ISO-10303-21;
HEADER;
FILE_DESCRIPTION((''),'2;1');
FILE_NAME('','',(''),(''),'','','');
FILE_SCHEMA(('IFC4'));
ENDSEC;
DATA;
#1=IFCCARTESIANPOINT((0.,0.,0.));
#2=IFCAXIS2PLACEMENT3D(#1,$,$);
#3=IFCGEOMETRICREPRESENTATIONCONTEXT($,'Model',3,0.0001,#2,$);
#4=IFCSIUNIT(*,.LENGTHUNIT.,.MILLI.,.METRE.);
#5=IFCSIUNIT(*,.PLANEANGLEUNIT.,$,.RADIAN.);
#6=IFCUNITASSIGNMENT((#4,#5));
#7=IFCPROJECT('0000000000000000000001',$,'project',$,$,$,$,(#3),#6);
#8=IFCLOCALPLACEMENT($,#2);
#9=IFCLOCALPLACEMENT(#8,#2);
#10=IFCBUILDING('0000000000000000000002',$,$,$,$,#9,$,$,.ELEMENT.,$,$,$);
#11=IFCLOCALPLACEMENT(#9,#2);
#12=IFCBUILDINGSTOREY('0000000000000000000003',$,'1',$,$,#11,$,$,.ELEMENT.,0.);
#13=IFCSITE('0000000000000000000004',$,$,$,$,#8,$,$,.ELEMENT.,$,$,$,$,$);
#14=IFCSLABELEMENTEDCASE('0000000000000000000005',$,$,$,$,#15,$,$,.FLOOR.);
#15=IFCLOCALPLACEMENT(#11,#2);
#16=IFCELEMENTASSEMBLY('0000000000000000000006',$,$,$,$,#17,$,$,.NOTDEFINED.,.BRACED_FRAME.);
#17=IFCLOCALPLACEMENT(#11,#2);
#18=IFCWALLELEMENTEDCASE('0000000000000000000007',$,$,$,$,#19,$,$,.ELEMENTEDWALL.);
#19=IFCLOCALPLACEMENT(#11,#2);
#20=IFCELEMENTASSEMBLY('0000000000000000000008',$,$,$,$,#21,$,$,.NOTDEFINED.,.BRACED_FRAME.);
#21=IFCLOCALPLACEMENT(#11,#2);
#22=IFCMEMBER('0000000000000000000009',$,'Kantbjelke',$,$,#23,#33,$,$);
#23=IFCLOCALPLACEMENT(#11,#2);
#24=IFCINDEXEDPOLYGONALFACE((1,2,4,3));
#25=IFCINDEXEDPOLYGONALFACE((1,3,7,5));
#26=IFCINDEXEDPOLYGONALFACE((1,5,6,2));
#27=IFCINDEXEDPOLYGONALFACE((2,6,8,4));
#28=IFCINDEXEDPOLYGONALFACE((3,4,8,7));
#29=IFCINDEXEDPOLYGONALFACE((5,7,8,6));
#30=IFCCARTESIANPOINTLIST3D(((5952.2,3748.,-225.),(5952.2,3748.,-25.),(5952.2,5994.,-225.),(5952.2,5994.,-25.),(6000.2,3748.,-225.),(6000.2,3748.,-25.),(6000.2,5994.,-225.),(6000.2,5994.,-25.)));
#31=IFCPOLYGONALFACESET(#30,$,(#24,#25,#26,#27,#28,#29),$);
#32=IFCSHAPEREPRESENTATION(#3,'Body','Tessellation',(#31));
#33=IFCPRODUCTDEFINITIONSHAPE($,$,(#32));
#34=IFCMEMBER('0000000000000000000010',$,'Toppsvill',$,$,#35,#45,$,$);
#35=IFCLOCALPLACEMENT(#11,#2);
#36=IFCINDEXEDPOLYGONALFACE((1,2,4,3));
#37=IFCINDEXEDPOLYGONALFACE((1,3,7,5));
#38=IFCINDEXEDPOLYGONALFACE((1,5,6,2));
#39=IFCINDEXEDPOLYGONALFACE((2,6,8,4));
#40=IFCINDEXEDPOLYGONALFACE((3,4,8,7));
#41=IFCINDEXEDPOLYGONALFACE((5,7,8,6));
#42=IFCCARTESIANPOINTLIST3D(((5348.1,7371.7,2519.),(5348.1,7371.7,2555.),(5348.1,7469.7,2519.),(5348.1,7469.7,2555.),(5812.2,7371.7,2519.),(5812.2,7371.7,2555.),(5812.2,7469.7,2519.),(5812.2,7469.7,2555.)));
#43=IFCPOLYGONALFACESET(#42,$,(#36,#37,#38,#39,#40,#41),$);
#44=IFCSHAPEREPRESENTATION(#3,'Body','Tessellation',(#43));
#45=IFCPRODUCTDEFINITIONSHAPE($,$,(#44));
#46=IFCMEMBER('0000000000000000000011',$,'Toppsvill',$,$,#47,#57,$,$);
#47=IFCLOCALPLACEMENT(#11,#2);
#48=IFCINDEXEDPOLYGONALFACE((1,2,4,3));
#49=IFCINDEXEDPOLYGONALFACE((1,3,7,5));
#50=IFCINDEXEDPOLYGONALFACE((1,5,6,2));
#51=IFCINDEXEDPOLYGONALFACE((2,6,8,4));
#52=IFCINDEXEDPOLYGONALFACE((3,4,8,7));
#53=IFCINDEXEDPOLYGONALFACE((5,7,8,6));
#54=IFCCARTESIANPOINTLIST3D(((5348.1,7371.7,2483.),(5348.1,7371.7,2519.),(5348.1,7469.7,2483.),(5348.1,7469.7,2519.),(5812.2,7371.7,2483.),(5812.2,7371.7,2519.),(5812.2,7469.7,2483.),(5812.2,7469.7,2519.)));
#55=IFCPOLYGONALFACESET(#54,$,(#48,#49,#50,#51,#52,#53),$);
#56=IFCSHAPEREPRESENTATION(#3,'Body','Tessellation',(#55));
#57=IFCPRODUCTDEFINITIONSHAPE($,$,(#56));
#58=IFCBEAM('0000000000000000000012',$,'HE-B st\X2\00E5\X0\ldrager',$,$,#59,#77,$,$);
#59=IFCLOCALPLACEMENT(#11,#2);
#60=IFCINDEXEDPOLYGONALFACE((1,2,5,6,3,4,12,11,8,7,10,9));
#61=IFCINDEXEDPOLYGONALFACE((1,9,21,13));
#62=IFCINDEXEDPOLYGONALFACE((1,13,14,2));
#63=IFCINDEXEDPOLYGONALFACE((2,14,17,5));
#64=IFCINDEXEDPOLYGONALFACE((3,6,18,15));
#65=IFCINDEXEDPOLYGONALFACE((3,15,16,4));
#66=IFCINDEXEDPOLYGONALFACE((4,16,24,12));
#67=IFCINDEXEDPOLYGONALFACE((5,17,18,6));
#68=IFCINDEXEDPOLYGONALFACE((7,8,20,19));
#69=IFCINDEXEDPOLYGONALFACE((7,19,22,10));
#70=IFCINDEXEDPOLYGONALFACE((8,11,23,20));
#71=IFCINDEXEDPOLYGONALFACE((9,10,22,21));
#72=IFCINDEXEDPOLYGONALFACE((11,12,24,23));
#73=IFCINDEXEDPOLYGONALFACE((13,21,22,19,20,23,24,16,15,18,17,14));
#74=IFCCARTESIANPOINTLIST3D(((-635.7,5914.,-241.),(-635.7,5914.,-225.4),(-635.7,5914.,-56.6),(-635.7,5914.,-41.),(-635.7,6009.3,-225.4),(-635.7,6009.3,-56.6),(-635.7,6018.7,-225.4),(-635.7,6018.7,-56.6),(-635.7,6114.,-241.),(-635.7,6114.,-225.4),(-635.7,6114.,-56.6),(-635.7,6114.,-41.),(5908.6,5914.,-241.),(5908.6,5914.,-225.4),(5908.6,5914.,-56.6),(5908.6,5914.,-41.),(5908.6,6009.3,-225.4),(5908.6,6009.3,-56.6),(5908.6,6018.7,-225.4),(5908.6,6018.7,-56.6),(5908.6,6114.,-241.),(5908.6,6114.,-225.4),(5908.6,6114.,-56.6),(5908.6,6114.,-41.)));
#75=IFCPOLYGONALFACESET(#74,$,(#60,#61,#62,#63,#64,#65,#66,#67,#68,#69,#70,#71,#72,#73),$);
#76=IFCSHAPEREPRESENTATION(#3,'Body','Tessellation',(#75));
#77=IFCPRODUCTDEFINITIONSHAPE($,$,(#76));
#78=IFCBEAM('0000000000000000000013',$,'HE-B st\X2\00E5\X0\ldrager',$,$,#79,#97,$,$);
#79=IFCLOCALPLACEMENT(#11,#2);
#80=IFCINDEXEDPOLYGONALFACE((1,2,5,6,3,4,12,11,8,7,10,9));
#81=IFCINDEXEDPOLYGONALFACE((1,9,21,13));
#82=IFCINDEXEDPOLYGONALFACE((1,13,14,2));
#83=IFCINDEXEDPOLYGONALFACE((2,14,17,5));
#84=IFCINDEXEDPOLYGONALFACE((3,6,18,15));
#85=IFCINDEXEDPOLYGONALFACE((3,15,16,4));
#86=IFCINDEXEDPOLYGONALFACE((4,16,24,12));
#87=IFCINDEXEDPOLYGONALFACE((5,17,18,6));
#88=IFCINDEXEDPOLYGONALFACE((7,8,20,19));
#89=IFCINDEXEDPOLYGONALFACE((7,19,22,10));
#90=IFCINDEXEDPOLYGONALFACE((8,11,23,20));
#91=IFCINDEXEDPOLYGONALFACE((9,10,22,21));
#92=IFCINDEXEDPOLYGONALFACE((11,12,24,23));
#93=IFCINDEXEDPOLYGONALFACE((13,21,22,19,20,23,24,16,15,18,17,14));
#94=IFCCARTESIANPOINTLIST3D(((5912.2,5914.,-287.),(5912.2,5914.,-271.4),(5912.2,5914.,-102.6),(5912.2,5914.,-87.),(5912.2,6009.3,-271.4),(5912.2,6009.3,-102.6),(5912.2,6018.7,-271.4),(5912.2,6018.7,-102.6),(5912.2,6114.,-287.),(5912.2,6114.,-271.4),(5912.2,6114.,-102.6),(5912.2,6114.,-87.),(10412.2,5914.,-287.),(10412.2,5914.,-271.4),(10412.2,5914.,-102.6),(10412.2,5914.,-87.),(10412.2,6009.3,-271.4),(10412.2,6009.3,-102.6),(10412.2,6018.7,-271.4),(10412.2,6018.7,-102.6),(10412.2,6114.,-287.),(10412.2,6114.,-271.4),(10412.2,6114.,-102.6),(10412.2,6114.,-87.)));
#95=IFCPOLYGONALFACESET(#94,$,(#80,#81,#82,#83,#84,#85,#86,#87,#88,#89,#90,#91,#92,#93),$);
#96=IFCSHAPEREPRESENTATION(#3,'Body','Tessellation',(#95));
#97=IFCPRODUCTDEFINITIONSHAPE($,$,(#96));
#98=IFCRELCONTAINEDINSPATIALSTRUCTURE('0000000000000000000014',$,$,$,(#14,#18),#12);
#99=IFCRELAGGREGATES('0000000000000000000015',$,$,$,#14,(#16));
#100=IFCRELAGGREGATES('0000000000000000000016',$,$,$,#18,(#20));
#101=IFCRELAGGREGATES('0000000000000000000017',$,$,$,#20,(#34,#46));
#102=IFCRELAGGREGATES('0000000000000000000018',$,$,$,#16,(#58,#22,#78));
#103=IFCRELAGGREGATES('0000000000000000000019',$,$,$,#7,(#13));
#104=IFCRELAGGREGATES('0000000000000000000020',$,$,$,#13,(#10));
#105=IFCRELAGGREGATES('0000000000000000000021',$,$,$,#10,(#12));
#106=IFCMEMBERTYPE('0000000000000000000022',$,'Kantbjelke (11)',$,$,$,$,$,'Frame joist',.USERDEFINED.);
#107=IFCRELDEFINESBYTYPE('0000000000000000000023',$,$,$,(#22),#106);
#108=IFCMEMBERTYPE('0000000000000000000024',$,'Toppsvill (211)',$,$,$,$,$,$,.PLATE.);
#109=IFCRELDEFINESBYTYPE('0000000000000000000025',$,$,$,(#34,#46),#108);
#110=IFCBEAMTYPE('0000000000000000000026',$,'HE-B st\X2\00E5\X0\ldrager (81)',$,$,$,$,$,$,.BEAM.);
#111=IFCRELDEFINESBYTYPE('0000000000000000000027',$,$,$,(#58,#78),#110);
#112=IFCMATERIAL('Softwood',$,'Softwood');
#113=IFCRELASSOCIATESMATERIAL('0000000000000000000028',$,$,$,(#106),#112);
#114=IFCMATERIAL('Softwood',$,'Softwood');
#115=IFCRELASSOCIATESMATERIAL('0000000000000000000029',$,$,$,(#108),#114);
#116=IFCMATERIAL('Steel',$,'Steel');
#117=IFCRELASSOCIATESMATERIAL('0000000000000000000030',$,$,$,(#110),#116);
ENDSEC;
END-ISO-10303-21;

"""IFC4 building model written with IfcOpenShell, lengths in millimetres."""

from ifc_helpers import new_model, si_unit, frame, origin, place, context, project, spatial, polyline, rectangle, outline, extrude, clip, halfspace, material, material_profile, profile_set, type_object, element, aggregate, save


model = new_model("IFC4")

# Units and contexts
model_context = context("Model", 3, precision=0.0001, world=origin())
ifc_project = project(units=[si_unit("LENGTHUNIT", "METRE", prefix="MILLI"), si_unit("PLANEANGLEUNIT", "RADIAN")], contexts=[model_context])

# Site, building, storey
site_placement = place(None, origin())
site = spatial("IfcSite", under=ifc_project, at=site_placement, CompositionType="ELEMENT")
building_placement = place(site_placement, origin())
building = spatial("IfcBuilding", under=site, at=building_placement, CompositionType="ELEMENT")
storey_placement = place(building_placement, origin())
storey = spatial("IfcBuildingStorey", under=building, at=storey_placement, Name="1", CompositionType="ELEMENT", Elevation=0.0)

# Slab, element assembly
slab_placement = place(storey_placement, origin())
slab = element("IfcSlabElementedCase", 1, at=slab_placement, inside=storey, PredefinedType="FLOOR")
assembly_1_placement = place(slab_placement, frame((0.0, 0.0, -225.0)))
assembly_1 = element("IfcElementAssembly", 2, at=assembly_1_placement, AssemblyPlace="NOTDEFINED", PredefinedType="BRACED_FRAME")
aggregate(slab, [assembly_1])

# Wall, element assembly
wall_1_placement = place(storey_placement, frame((5812.2, 7371.7, 0.0), z_axis=(0.0, 1.0, 0.0), x_axis=(-1.0, 0.0, 0.0)))
wall_1 = element("IfcWallElementedCase", 3, at=wall_1_placement, inside=storey, PredefinedType="ELEMENTEDWALL")
assembly_2_placement = place(wall_1_placement, origin())
assembly_2 = element("IfcElementAssembly", 4, at=assembly_2_placement, AssemblyPlace="NOTDEFINED", PredefinedType="BRACED_FRAME")
aggregate(wall_1, [assembly_2])

# Members
ifc_material_1 = material(Name="Softwood", Category="Softwood")
ifc_material_profile_1 = material_profile(ifc_material_1, rectangle(XDim=48.0, YDim=200.0), Name="Kantbjelke (11)")
ifc_profile_set_1 = profile_set([ifc_material_profile_1])
member_type_1 = type_object("IfcMemberType", Name="Kantbjelke (11)", ElementType="Frame joist", PredefinedType="USERDEFINED", material=ifc_profile_set_1)
member_1_placement = place(assembly_1_placement, frame((5976.2, 3748.0, 0.0), z_axis=(0.0, 1.0, 0.0), x_axis=(-1.0, 0.0, 0.0)))
member_1 = element("IfcMember", 5, at=member_1_placement, type_object=member_type_1, Name="Kantbjelke", context=model_context, shape_type="SweptSolid", body=[
    extrude(rectangle(XDim=48.0, YDim=200.0), frame((0.0, 100.0, 0.0)), (0.0, 0.0, 1.0), 2246.0),
])
ifc_material_2 = material(Name="Softwood", Category="Softwood")
ifc_material_profile_2 = material_profile(ifc_material_2, rectangle(XDim=36.0, YDim=98.0), Name="Toppsvill (211)")
ifc_profile_set_2 = profile_set([ifc_material_profile_2])
member_type_2 = type_object("IfcMemberType", Name="Toppsvill (211)", PredefinedType="PLATE", material=ifc_profile_set_2)
member_2_placement = place(assembly_2_placement, frame((0.0, 2537.0, 0.0), z_axis=(1.0, 0.0, 0.0), x_axis=(0.0, 1.0, 0.0)))
member_2 = element("IfcMember", 6, at=member_2_placement, type_object=member_type_2, Name="Toppsvill", context=model_context, shape_type="Clipping", body=[
    clip(clip(extrude(rectangle(XDim=36.0, YDim=98.0), frame((0.0, 49.0, 0.0)), (0.0, 0.0, 1.0), 464.1), halfspace(frame((0.0, 49.0, 0.0)), True)), halfspace(frame((0.0, 49.0, 464.1)), False)),
])
member_3_placement = place(assembly_2_placement, frame((0.0, 2501.0, 0.0), z_axis=(1.0, 0.0, 0.0), x_axis=(0.0, 1.0, 0.0)))
member_3 = element("IfcMember", 7, at=member_3_placement, type_object=member_type_2, Name="Toppsvill", context=model_context, shape_type="SweptSolid", body=[
    extrude(rectangle(XDim=36.0, YDim=98.0), frame((0.0, 49.0, 0.0)), (0.0, 0.0, 1.0), 464.1),
])
aggregate(assembly_2, [member_2, member_3])

# Beams
ifc_material_3 = material(Name="Steel", Category="Steel")
ifc_material_profile_3 = material_profile(ifc_material_3, outline(polyline([(100.0, -100.0), (100.0, -84.4), (4.7, -84.4), (4.7, 84.4), (100.0, 84.4), (100.0, 100.0), (-100.0, 100.0), (-100.0, 84.4), (-4.7, 84.4), (-4.7, -84.4), (-100.0, -84.4), (-100.0, -100.0)])), Name="HE-B ståldrager (81)")
ifc_profile_set_3 = profile_set([ifc_material_profile_3])
beam_type = type_object("IfcBeamType", Name="HE-B ståldrager (81)", PredefinedType="BEAM", material=ifc_profile_set_3)
beam_1_placement = place(assembly_1_placement, frame((5908.6, 6014.0, -16.0), z_axis=(-1.0, 0.0, 0.0), x_axis=(0.0, -1.0, 0.0)))
beam_1 = element("IfcBeam", 8, at=beam_1_placement, type_object=beam_type, Name="HE-B ståldrager", context=model_context, shape_type="Clipping", body=[
    clip(clip(extrude(outline(polyline([(100.0, -100.0), (100.0, -84.4), (4.7, -84.4), (4.7, 84.4), (100.0, 84.4), (100.0, 100.0), (-100.0, 100.0), (-100.0, 84.4), (-4.7, 84.4), (-4.7, -84.4), (-100.0, -84.4), (-100.0, -100.0)])), frame((0.0, 100.0, 0.0)), (0.0, 0.0, 1.0), 6544.3), halfspace(frame((0.0, 100.0, 0.0)), True)), halfspace(frame((0.0, 100.0, 6544.3)), False)),
])
beam_2_placement = place(assembly_1_placement, frame((5912.2, 6014.0, -62.0), z_axis=(1.0, 0.0, 0.0), x_axis=(0.0, 1.0, 0.0)))
beam_2 = element("IfcBeam", 9, at=beam_2_placement, type_object=beam_type, Name="HE-B ståldrager", context=model_context, shape_type="Clipping", body=[
    clip(clip(extrude(outline(polyline([(100.0, -100.0), (100.0, -84.4), (4.7, -84.4), (4.7, 84.4), (100.0, 84.4), (100.0, 100.0), (-100.0, 100.0), (-100.0, 84.4), (-4.7, 84.4), (-4.7, -84.4), (-100.0, -84.4), (-100.0, -100.0)])), frame((0.0, 100.0, 0.0)), (0.0, 0.0, 1.0), 4500.0), halfspace(frame((0.0, 100.0, 0.0)), True)), halfspace(frame((0.0, 100.0, 4500.0)), False)),
])
aggregate(assembly_1, [beam_1, member_1, beam_2])

save(model, "model.ifc")
